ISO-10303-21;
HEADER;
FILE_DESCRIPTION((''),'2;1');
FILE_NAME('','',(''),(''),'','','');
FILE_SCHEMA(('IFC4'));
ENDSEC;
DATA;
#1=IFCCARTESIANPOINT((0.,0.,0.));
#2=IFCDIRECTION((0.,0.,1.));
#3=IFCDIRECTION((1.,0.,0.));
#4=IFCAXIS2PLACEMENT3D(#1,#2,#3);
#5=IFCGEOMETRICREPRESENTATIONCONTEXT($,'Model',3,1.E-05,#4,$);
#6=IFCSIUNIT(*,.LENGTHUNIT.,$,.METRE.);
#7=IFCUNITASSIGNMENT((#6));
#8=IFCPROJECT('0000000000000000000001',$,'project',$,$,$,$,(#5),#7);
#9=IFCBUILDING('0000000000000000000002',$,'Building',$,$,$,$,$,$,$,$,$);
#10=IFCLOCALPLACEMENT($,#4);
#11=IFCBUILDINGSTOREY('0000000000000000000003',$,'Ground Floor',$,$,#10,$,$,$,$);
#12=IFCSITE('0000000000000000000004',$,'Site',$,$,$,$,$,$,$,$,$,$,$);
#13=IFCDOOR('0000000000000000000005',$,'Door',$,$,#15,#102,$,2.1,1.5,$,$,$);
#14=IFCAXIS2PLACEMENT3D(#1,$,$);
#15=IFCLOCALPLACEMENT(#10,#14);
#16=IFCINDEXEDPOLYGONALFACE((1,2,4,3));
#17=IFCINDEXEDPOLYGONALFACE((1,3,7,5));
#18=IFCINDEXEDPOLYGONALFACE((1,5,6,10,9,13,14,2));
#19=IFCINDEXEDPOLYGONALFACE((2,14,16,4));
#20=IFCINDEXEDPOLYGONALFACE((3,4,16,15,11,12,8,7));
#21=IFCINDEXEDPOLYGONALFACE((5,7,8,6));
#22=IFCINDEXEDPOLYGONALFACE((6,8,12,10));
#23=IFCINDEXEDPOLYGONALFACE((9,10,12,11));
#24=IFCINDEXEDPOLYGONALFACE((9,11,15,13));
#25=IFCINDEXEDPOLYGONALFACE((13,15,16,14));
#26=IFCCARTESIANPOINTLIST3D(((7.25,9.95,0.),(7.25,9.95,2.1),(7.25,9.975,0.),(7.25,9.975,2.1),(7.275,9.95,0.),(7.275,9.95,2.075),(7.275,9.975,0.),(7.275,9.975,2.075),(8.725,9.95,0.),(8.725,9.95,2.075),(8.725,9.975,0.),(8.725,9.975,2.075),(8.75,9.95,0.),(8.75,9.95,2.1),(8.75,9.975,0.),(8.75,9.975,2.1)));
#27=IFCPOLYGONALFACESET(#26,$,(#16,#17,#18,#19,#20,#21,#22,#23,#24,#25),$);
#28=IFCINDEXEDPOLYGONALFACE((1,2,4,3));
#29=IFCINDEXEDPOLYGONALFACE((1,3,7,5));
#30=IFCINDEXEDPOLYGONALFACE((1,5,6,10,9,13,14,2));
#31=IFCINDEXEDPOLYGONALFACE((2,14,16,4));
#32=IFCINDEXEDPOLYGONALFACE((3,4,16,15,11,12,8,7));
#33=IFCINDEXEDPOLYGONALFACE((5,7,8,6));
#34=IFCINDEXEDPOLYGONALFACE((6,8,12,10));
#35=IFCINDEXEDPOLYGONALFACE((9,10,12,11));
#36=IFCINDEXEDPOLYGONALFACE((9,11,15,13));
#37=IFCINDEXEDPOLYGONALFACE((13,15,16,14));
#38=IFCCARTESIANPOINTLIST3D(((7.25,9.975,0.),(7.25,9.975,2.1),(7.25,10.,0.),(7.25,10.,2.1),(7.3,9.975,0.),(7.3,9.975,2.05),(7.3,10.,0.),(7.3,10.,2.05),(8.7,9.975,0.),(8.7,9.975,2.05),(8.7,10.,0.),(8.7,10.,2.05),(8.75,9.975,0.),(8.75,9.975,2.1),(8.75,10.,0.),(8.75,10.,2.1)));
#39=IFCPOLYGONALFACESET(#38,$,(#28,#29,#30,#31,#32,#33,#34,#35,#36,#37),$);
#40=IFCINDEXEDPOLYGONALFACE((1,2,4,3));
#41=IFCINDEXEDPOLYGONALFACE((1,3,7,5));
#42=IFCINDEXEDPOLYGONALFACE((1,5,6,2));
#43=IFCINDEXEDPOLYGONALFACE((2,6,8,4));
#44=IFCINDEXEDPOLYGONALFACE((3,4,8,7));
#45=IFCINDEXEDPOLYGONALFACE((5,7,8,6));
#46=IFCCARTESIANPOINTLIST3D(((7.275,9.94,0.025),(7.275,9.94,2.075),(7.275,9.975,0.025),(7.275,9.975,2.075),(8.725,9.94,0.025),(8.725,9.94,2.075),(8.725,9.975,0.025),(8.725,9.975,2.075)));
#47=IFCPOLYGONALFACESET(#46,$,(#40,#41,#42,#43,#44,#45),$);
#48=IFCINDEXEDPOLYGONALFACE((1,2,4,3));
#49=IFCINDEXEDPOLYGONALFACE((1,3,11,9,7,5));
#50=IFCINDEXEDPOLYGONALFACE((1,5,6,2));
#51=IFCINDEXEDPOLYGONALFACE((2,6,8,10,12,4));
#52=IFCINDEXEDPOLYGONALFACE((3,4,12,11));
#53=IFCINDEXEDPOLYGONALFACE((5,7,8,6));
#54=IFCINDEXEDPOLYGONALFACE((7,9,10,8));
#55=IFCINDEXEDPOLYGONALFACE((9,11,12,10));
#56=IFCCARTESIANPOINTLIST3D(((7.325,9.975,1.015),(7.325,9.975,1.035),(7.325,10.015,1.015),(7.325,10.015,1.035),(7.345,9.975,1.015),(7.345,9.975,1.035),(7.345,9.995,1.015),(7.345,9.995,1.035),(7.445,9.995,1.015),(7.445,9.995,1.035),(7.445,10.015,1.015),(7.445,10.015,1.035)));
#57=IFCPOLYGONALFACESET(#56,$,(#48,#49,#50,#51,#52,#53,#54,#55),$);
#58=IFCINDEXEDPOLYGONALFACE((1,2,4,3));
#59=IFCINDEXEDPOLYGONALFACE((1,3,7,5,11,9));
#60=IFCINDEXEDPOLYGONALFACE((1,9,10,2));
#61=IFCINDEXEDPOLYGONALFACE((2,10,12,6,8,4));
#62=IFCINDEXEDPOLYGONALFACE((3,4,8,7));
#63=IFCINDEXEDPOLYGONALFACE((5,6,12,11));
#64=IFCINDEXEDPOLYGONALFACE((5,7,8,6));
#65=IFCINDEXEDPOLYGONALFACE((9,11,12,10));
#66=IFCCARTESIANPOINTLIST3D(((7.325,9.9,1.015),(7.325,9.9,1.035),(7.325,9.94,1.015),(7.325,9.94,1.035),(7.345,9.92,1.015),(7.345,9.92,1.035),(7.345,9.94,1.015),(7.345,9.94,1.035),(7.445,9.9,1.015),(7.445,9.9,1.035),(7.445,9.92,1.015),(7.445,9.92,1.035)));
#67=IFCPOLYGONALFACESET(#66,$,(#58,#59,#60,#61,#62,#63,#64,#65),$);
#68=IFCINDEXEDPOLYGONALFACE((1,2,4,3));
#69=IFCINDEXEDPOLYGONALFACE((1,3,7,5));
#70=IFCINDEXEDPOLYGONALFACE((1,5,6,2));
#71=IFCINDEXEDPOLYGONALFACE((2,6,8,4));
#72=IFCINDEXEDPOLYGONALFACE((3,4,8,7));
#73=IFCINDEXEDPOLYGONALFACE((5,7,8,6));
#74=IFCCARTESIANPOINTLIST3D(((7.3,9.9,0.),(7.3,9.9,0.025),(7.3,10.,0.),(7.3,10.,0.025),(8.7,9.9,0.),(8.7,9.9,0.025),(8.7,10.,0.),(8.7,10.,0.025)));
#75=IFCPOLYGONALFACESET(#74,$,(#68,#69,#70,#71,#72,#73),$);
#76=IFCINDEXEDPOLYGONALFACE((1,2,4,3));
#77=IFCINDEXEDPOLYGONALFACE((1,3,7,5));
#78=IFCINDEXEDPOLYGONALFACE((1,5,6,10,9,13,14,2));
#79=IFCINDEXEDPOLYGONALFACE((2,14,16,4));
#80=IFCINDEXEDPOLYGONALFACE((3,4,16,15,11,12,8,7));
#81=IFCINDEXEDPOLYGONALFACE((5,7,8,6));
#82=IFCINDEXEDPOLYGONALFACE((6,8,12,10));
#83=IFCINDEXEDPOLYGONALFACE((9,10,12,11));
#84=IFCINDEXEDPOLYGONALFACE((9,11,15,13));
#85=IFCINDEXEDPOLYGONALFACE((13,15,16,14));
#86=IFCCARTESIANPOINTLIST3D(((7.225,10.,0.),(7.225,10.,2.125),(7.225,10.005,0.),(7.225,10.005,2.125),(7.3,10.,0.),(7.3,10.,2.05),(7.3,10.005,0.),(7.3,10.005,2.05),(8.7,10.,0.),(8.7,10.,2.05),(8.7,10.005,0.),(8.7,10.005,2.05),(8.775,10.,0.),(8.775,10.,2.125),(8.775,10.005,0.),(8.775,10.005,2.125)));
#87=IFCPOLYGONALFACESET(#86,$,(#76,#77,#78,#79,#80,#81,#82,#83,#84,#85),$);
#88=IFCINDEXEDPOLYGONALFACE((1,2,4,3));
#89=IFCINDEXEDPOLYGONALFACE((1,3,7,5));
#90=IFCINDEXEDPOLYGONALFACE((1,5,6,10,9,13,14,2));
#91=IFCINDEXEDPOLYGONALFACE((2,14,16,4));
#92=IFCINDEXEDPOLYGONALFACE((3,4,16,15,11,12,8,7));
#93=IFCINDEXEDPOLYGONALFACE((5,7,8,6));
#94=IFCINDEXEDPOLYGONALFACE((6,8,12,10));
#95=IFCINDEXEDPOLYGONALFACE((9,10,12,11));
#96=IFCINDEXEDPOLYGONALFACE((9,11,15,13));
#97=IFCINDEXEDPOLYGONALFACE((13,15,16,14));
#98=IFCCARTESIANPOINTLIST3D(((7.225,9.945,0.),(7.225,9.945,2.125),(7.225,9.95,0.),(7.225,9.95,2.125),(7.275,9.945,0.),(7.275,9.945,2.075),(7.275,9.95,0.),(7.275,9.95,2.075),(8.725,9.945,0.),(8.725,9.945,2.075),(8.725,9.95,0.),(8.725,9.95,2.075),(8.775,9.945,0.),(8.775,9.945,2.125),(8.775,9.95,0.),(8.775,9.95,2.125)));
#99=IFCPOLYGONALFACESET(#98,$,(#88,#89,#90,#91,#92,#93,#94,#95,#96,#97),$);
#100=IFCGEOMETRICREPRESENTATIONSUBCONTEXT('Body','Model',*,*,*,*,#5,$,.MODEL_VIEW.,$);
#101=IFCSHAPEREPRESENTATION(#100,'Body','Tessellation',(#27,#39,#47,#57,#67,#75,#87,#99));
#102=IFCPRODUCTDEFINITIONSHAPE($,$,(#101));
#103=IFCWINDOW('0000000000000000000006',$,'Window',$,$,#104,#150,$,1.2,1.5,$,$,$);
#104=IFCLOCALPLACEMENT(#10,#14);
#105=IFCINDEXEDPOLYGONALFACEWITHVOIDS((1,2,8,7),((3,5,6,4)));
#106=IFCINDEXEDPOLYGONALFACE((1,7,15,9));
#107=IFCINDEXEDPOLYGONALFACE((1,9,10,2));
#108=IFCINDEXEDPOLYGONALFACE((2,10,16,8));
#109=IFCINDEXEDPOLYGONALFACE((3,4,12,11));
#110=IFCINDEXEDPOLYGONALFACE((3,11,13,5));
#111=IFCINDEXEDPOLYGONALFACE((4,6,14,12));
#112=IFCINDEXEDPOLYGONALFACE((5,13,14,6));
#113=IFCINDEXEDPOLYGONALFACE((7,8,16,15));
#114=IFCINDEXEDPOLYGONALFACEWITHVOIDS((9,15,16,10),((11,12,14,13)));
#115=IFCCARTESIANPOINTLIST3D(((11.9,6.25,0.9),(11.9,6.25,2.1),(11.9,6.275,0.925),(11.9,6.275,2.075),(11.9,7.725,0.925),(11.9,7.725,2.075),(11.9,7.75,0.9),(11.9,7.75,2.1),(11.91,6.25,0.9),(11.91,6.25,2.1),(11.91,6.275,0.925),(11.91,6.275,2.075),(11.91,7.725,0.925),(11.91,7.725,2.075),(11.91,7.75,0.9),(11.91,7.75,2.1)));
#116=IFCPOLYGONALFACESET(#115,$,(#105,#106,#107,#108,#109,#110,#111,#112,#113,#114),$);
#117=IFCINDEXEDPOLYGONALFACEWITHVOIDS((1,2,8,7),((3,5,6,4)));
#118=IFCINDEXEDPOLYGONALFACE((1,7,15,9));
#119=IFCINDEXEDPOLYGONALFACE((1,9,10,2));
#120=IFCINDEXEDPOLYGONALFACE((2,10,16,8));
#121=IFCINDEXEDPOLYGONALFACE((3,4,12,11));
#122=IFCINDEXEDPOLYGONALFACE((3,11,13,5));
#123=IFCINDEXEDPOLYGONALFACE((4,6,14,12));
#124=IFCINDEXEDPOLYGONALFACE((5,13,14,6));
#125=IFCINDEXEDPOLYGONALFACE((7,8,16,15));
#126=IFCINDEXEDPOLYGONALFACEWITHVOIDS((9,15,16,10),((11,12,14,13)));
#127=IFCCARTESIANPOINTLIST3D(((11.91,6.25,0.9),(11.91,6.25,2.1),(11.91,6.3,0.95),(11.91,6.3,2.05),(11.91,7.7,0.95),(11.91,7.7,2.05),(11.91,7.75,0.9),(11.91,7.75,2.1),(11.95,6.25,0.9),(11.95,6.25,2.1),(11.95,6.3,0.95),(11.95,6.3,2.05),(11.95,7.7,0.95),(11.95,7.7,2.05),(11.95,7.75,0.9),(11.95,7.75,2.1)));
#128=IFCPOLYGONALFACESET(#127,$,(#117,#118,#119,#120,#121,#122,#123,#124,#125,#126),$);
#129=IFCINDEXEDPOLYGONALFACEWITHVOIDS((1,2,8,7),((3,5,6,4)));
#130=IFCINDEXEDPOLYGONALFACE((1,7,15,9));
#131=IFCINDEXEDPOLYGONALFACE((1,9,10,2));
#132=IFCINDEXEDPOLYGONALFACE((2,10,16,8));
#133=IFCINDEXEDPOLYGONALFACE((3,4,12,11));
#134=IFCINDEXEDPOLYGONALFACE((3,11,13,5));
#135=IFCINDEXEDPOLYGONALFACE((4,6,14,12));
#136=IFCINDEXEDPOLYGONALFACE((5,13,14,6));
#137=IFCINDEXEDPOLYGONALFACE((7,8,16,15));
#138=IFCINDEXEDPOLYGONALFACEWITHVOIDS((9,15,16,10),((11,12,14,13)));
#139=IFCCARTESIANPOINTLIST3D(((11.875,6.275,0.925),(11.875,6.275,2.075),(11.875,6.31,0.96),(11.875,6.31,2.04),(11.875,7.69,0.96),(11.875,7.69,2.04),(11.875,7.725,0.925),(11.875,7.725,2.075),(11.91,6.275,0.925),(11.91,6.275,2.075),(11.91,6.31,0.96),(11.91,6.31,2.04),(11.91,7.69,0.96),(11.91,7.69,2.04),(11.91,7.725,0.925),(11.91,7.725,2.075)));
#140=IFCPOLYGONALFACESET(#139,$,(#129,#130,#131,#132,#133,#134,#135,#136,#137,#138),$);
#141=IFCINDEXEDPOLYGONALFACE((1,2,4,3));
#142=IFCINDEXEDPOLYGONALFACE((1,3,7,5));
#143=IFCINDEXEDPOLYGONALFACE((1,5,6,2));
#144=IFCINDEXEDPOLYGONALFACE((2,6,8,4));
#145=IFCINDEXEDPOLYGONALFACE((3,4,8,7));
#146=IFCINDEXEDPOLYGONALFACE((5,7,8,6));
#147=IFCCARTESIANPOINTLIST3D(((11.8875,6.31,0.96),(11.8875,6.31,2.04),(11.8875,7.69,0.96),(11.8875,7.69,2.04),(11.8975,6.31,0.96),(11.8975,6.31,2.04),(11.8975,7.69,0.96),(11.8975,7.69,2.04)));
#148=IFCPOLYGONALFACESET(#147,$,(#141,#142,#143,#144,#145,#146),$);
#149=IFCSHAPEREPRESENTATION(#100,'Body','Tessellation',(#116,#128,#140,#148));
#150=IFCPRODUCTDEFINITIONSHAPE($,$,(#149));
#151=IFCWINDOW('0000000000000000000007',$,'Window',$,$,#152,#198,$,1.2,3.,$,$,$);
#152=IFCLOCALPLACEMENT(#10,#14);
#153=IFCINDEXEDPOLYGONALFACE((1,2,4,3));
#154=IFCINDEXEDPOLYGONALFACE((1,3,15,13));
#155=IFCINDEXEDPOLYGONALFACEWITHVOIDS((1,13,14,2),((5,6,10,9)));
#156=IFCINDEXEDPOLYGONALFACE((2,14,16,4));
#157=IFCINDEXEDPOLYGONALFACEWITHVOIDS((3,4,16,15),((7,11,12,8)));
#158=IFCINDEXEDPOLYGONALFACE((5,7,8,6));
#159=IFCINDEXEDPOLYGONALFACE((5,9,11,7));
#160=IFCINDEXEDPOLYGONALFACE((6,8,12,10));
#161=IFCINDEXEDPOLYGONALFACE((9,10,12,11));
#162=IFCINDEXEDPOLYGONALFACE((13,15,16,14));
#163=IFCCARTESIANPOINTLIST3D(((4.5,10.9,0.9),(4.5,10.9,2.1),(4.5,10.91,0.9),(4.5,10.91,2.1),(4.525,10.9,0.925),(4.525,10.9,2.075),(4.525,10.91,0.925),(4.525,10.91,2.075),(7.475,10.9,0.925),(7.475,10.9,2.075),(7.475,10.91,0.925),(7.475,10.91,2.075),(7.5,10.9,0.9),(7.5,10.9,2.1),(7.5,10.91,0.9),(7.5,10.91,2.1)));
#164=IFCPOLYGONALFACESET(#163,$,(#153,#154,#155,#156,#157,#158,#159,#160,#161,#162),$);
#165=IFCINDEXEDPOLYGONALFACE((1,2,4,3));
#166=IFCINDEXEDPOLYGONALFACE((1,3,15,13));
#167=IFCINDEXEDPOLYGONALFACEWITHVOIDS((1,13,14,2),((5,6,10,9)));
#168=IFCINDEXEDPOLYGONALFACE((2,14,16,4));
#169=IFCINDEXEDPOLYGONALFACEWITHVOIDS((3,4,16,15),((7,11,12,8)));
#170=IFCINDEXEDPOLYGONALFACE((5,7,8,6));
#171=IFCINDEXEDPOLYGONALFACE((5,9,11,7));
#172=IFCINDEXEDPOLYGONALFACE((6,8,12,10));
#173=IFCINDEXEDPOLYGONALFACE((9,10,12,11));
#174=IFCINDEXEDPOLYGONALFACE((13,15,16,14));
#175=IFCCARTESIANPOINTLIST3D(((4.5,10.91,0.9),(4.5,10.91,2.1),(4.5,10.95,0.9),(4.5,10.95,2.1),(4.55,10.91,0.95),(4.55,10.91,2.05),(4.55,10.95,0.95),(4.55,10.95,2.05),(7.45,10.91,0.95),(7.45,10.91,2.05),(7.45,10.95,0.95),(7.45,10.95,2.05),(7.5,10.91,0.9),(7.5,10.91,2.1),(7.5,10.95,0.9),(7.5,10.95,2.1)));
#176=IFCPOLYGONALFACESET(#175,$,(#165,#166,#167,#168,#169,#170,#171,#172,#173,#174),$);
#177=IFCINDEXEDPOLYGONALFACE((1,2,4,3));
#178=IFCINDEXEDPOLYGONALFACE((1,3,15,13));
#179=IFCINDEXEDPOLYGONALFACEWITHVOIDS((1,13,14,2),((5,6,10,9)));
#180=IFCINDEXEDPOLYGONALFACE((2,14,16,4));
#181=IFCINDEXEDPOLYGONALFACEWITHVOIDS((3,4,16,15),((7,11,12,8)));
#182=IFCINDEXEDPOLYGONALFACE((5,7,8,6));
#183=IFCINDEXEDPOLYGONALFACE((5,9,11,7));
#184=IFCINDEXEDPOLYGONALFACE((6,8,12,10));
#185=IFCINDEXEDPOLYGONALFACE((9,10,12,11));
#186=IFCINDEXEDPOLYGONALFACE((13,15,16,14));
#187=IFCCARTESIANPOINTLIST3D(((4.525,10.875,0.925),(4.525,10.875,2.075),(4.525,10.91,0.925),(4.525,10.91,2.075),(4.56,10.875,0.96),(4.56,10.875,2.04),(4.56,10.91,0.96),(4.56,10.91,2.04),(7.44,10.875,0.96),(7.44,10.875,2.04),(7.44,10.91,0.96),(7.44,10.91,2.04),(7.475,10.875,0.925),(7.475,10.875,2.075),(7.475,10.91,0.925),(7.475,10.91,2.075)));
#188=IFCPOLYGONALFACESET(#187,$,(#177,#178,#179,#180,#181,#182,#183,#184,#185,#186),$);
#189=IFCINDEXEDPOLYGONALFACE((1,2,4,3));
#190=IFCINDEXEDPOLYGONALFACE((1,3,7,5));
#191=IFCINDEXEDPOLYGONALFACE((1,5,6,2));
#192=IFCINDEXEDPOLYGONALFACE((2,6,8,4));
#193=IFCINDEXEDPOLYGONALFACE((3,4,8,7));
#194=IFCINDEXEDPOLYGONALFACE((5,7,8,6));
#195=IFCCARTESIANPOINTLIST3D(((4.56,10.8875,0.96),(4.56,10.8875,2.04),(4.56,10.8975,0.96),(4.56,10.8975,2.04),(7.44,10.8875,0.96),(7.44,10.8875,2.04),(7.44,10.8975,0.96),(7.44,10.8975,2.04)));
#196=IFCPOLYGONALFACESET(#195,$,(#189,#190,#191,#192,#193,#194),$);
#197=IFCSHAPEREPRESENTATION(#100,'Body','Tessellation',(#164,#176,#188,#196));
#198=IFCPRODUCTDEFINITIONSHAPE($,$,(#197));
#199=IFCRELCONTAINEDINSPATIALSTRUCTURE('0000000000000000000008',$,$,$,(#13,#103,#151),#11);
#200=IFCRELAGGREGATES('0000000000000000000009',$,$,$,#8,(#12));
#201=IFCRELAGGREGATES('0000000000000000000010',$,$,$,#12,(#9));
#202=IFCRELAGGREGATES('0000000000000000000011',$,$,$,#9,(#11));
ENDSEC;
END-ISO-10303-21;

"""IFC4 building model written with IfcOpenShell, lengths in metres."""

from ifc_helpers import new_model, si_unit, frame, origin_with_axes, place, context, subcontext, project, spatial, line, indexed_curve, outline, extrude, element, save


model = new_model("IFC4")

# Units and contexts
model_context = context("Model", 3, precision=1e-05, world=origin_with_axes())
body_context = subcontext(model_context, "Body", "Model", "MODEL_VIEW")
ifc_project = project(units=[si_unit("LENGTHUNIT", "METRE")], contexts=[model_context])

# Site, building, storey
site = spatial("IfcSite", under=ifc_project, Name="Site")
building = spatial("IfcBuilding", under=site, Name="Building")
storey_placement = place(None, origin_with_axes())
storey = spatial("IfcBuildingStorey", under=building, at=storey_placement, Name="Ground Floor")

# Door
door_1_placement = place(storey_placement, frame((8.75, 10.0, 0.0), z_axis=(0.0, 0.0, 1.0), x_axis=(-1.0, 0.0, 0.0)))
element("IfcDoor", 1, at=door_1_placement, inside=storey, Name="Door", OverallHeight=2.1, OverallWidth=1.5, context=body_context, shape_type="SweptSolid", body=[
    extrude(outline(indexed_curve([(0.0, 0.0), (0.0, 2.1), (1.5, 2.1), (1.5, 0.0), (1.475, 0.0), (1.475, 2.075), (0.025, 2.075), (0.025, 0.0)], segments=[line(1, 2, 3, 4, 5, 6, 7, 8, 1)])), frame((0.0, 0.025, 0.0), z_axis=(0.0, -1.0, 0.0), x_axis=(1.0, 0.0, 0.0)), (0.0, 0.0, -1.0), 0.025),
    extrude(outline(indexed_curve([(0.0, 0.0), (0.0, 2.1), (1.5, 2.1), (1.5, 0.0), (1.45, 0.0), (1.45, 2.05), (0.05, 2.05), (0.05, 0.0)], segments=[line(1, 2, 3, 4, 5, 6, 7, 8, 1)])), frame((0.0, 0.0, 0.0), z_axis=(0.0, -1.0, 0.0), x_axis=(1.0, 0.0, 0.0)), (0.0, 0.0, -1.0), 0.025),
    extrude(outline(indexed_curve([(0.0, 0.0), (1.45, 0.0), (1.45, 0.035), (0.0, 0.035)], segments=[line(1, 2, 3, 4, 1)])), frame((0.025, 0.025, 0.025), z_axis=(0.0, 0.0, 1.0), x_axis=(1.0, 0.0, 0.0)), (0.0, 0.0, 1.0), 2.05),
    extrude(outline(indexed_curve([(0.0, 0.0), (0.0, -0.04), (-0.12, -0.04), (-0.12, -0.02), (-0.02, -0.02), (-0.02, 0.0)], segments=[line(1, 2, 3, 4, 5, 6, 1)])), frame((1.425, 0.025, 1.015), z_axis=(0.0, 0.0, 1.0), x_axis=(1.0, 0.0, 0.0)), (0.0, 0.0, 1.0), 0.02),
    extrude(outline(indexed_curve([(0.0, 0.0), (0.0, 0.04), (-0.12, 0.04), (-0.12, 0.02), (-0.02, 0.02), (-0.02, 0.0)], segments=[line(1, 2, 3, 4, 5, 6, 1)])), frame((1.425, 0.06, 1.015), z_axis=(0.0, 0.0, 1.0), x_axis=(1.0, 0.0, 0.0)), (0.0, 0.0, 1.0), 0.02),
    extrude(outline(indexed_curve([(0.0, 0.0), (1.4, 0.0), (1.4, 0.1), (0.0, 0.1)], segments=[line(1, 2, 3, 4, 1)])), frame((0.05, 0.0, 0.0), z_axis=(0.0, 0.0, 1.0), x_axis=(1.0, 0.0, 0.0)), (0.0, 0.0, 1.0), 0.025),
    extrude(outline(indexed_curve([(0.0, 0.0), (0.0, 2.125), (1.55, 2.125), (1.55, 0.0), (1.475, 0.0), (1.475, 2.05), (0.075, 2.05), (0.075, 0.0)], segments=[line(1, 2, 3, 4, 5, 6, 7, 8, 1)])), frame((-0.025, -0.005, 0.0), z_axis=(0.0, -1.0, 0.0), x_axis=(1.0, 0.0, 0.0)), (0.0, 0.0, -1.0), 0.005),
    extrude(outline(indexed_curve([(0.0, 0.0), (0.0, 2.125), (1.55, 2.125), (1.55, 0.0), (1.5, 0.0), (1.5, 2.075), (0.05, 2.075), (0.05, 0.0)], segments=[line(1, 2, 3, 4, 5, 6, 7, 8, 1)])), frame((-0.025, 0.05, 0.0), z_axis=(0.0, -1.0, 0.0), x_axis=(1.0, 0.0, 0.0)), (0.0, 0.0, -1.0), 0.005),
])

# Windows
window_1_placement = place(storey_placement, frame((12.0, 6.25, 0.9), z_axis=(0.0, 0.0, 1.0), x_axis=(0.0, 1.0, 0.0)))
element("IfcWindow", 2, at=window_1_placement, inside=storey, Name="Window", OverallHeight=1.2, OverallWidth=1.5, context=body_context, shape_type="SweptSolid", body=[
    extrude(outline(indexed_curve([(0.0, 0.0), (1.5, 0.0), (1.5, 1.2), (0.0, 1.2)], segments=[line(1, 2, 3, 4, 1)]), holes=[indexed_curve([(0.025, 0.025), (1.475, 0.025), (1.475, 1.175), (0.025, 1.175)], segments=[line(1, 2, 3, 4, 1)])]), frame((0.0, 0.09, 0.0), z_axis=(0.0, -1.0, 0.0), x_axis=(1.0, 0.0, 0.0)), (0.0, 0.0, -1.0), 0.01),
    extrude(outline(indexed_curve([(0.0, 0.0), (1.5, 0.0), (1.5, 1.2), (0.0, 1.2)], segments=[line(1, 2, 3, 4, 1)]), holes=[indexed_curve([(0.05, 0.05), (1.45, 0.05), (1.45, 1.15), (0.05, 1.15)], segments=[line(1, 2, 3, 4, 1)])]), frame((0.0, 0.05, 0.0), z_axis=(0.0, -1.0, 0.0), x_axis=(1.0, 0.0, 0.0)), (0.0, 0.0, -1.0), 0.04),
    extrude(outline(indexed_curve([(0.0, 0.0), (1.45, 0.0), (1.45, 1.15), (0.0, 1.15)], segments=[line(1, 2, 3, 4, 1)]), holes=[indexed_curve([(0.035, 0.035), (1.415, 0.035), (1.415, 1.115), (0.035, 1.115)], segments=[line(1, 2, 3, 4, 1)])]), frame((0.025, 0.09, 0.025), z_axis=(0.0, -1.0, 0.0), x_axis=(1.0, 0.0, 0.0)), (0.0, 0.0, -1.0), 0.035),
    extrude(outline(indexed_curve([(0.035, 0.035), (1.415, 0.035), (1.415, 1.115), (0.035, 1.115)], segments=[line(1, 2, 3, 4, 1)])), frame((0.025, 0.1025, 0.025), z_axis=(0.0, -1.0, 0.0), x_axis=(1.0, 0.0, 0.0)), (0.0, 0.0, -1.0), 0.01),
])
window_2_placement = place(storey_placement, frame((7.5, 11.0, 0.9), z_axis=(0.0, 0.0, 1.0), x_axis=(-1.0, 0.0, 0.0)))
element("IfcWindow", 3, at=window_2_placement, inside=storey, Name="Window", OverallHeight=1.2, OverallWidth=3.0, context=body_context, shape_type="SweptSolid", body=[
    extrude(outline(indexed_curve([(0.0, 0.0), (3.0, 0.0), (3.0, 1.2), (0.0, 1.2)], segments=[line(1, 2, 3, 4, 1)]), holes=[indexed_curve([(0.025, 0.025), (2.975, 0.025), (2.975, 1.175), (0.025, 1.175)], segments=[line(1, 2, 3, 4, 1)])]), frame((0.0, 0.09, 0.0), z_axis=(0.0, -1.0, 0.0), x_axis=(1.0, 0.0, 0.0)), (0.0, 0.0, -1.0), 0.01),
    extrude(outline(indexed_curve([(0.0, 0.0), (3.0, 0.0), (3.0, 1.2), (0.0, 1.2)], segments=[line(1, 2, 3, 4, 1)]), holes=[indexed_curve([(0.05, 0.05), (2.95, 0.05), (2.95, 1.15), (0.05, 1.15)], segments=[line(1, 2, 3, 4, 1)])]), frame((0.0, 0.05, 0.0), z_axis=(0.0, -1.0, 0.0), x_axis=(1.0, 0.0, 0.0)), (0.0, 0.0, -1.0), 0.04),
    extrude(outline(indexed_curve([(0.0, 0.0), (2.95, 0.0), (2.95, 1.15), (0.0, 1.15)], segments=[line(1, 2, 3, 4, 1)]), holes=[indexed_curve([(0.035, 0.035), (2.915, 0.035), (2.915, 1.115), (0.035, 1.115)], segments=[line(1, 2, 3, 4, 1)])]), frame((0.025, 0.09, 0.025), z_axis=(0.0, -1.0, 0.0), x_axis=(1.0, 0.0, 0.0)), (0.0, 0.0, -1.0), 0.035),
    extrude(outline(indexed_curve([(0.035, 0.035), (2.915, 0.035), (2.915, 1.115), (0.035, 1.115)], segments=[line(1, 2, 3, 4, 1)])), frame((0.025, 0.1025, 0.025), z_axis=(0.0, -1.0, 0.0), x_axis=(1.0, 0.0, 0.0)), (0.0, 0.0, -1.0), 0.01),
])

save(model, "model.ifc")
